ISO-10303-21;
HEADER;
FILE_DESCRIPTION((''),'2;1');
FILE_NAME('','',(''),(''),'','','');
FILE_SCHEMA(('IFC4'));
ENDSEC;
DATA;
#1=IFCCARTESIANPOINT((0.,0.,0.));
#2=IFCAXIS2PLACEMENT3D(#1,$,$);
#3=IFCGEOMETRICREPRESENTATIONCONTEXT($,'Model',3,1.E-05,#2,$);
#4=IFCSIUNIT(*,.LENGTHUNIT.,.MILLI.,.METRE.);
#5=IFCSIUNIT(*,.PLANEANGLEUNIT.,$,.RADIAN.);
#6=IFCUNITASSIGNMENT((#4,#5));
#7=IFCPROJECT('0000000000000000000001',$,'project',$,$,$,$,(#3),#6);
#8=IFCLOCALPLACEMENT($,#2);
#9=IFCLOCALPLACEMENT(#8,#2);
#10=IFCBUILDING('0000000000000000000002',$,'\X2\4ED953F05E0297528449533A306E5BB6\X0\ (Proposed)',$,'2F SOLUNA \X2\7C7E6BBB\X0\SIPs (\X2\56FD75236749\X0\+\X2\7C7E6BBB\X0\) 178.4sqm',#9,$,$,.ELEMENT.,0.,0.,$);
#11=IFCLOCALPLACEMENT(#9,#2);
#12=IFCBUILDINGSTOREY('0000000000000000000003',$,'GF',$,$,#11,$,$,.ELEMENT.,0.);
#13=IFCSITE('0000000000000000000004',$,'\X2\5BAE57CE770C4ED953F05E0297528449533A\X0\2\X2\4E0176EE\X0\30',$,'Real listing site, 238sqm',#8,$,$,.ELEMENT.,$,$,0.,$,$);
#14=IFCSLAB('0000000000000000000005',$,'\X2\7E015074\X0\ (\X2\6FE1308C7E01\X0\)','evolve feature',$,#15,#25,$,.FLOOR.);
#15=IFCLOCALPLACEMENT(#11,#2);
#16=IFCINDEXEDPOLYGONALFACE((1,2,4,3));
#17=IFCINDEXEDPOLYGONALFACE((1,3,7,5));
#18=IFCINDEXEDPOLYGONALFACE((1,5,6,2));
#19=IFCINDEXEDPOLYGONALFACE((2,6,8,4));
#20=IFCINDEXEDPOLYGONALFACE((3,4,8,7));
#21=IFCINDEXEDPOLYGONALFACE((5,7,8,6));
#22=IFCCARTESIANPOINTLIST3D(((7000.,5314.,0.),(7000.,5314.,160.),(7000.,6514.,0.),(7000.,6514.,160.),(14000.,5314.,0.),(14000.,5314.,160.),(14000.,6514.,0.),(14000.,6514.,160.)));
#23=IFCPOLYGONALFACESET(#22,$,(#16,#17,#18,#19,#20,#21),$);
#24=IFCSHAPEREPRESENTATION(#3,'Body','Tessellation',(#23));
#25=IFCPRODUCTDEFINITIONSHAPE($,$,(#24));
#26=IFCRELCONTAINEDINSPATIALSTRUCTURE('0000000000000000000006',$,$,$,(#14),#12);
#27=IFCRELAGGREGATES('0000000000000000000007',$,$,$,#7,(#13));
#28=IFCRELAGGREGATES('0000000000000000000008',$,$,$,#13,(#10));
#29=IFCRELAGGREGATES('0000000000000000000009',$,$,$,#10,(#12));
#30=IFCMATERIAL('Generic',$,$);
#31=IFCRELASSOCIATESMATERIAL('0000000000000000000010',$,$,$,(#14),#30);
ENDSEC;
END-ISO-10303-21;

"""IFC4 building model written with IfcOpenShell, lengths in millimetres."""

from ifc_helpers import new_model, si_unit, frame, frame_2d, origin, place, context, project, spatial, rectangle, extrude, material, element, save


model = new_model("IFC4")

# Units and contexts
model_context = context("Model", 3, precision=1e-05, world=origin())
ifc_project = project(units=[si_unit("LENGTHUNIT", "METRE", prefix="MILLI"), si_unit("PLANEANGLEUNIT", "RADIAN")], contexts=[model_context])

# Site, building, storey
site_placement = place(None, origin())
site = spatial("IfcSite", under=ifc_project, at=site_placement, Name="宮城県仙台市青葉区2丁目30", ObjectType="Real listing site, 238sqm", CompositionType="ELEMENT", RefElevation=0.0)
building_placement = place(site_placement, origin())
building = spatial("IfcBuilding", under=site, at=building_placement, Name="仙台市青葉区の家 (Proposed)", ObjectType="2F SOLUNA 籾殻SIPs (国産杉+籾殻) 178.4sqm", CompositionType="ELEMENT", ElevationOfRefHeight=0.0, ElevationOfTerrain=0.0)
storey_placement = place(building_placement, origin())
storey = spatial("IfcBuildingStorey", under=building, at=storey_placement, Name="GF", CompositionType="ELEMENT", Elevation=0.0)

# Slab
ifc_material_1 = material(Name="Generic")
slab_1_placement = place(storey_placement, frame((3500.0, 2657.0, 0.0)))
element("IfcSlab", 1, at=slab_1_placement, inside=storey, material=ifc_material_1, Name="縁側 (濡れ縁)", Description="evolve feature", PredefinedType="FLOOR", context=model_context, shape_type="SweptSolid", body=[
    extrude(rectangle(XDim=7000.0, YDim=1200.0, at=frame_2d((3500.0, 600.0))), frame((3500.0, 2657.0, 0.0)), (0.0, 0.0, 1.0), 160.0),
])

save(model, "model.ifc")
